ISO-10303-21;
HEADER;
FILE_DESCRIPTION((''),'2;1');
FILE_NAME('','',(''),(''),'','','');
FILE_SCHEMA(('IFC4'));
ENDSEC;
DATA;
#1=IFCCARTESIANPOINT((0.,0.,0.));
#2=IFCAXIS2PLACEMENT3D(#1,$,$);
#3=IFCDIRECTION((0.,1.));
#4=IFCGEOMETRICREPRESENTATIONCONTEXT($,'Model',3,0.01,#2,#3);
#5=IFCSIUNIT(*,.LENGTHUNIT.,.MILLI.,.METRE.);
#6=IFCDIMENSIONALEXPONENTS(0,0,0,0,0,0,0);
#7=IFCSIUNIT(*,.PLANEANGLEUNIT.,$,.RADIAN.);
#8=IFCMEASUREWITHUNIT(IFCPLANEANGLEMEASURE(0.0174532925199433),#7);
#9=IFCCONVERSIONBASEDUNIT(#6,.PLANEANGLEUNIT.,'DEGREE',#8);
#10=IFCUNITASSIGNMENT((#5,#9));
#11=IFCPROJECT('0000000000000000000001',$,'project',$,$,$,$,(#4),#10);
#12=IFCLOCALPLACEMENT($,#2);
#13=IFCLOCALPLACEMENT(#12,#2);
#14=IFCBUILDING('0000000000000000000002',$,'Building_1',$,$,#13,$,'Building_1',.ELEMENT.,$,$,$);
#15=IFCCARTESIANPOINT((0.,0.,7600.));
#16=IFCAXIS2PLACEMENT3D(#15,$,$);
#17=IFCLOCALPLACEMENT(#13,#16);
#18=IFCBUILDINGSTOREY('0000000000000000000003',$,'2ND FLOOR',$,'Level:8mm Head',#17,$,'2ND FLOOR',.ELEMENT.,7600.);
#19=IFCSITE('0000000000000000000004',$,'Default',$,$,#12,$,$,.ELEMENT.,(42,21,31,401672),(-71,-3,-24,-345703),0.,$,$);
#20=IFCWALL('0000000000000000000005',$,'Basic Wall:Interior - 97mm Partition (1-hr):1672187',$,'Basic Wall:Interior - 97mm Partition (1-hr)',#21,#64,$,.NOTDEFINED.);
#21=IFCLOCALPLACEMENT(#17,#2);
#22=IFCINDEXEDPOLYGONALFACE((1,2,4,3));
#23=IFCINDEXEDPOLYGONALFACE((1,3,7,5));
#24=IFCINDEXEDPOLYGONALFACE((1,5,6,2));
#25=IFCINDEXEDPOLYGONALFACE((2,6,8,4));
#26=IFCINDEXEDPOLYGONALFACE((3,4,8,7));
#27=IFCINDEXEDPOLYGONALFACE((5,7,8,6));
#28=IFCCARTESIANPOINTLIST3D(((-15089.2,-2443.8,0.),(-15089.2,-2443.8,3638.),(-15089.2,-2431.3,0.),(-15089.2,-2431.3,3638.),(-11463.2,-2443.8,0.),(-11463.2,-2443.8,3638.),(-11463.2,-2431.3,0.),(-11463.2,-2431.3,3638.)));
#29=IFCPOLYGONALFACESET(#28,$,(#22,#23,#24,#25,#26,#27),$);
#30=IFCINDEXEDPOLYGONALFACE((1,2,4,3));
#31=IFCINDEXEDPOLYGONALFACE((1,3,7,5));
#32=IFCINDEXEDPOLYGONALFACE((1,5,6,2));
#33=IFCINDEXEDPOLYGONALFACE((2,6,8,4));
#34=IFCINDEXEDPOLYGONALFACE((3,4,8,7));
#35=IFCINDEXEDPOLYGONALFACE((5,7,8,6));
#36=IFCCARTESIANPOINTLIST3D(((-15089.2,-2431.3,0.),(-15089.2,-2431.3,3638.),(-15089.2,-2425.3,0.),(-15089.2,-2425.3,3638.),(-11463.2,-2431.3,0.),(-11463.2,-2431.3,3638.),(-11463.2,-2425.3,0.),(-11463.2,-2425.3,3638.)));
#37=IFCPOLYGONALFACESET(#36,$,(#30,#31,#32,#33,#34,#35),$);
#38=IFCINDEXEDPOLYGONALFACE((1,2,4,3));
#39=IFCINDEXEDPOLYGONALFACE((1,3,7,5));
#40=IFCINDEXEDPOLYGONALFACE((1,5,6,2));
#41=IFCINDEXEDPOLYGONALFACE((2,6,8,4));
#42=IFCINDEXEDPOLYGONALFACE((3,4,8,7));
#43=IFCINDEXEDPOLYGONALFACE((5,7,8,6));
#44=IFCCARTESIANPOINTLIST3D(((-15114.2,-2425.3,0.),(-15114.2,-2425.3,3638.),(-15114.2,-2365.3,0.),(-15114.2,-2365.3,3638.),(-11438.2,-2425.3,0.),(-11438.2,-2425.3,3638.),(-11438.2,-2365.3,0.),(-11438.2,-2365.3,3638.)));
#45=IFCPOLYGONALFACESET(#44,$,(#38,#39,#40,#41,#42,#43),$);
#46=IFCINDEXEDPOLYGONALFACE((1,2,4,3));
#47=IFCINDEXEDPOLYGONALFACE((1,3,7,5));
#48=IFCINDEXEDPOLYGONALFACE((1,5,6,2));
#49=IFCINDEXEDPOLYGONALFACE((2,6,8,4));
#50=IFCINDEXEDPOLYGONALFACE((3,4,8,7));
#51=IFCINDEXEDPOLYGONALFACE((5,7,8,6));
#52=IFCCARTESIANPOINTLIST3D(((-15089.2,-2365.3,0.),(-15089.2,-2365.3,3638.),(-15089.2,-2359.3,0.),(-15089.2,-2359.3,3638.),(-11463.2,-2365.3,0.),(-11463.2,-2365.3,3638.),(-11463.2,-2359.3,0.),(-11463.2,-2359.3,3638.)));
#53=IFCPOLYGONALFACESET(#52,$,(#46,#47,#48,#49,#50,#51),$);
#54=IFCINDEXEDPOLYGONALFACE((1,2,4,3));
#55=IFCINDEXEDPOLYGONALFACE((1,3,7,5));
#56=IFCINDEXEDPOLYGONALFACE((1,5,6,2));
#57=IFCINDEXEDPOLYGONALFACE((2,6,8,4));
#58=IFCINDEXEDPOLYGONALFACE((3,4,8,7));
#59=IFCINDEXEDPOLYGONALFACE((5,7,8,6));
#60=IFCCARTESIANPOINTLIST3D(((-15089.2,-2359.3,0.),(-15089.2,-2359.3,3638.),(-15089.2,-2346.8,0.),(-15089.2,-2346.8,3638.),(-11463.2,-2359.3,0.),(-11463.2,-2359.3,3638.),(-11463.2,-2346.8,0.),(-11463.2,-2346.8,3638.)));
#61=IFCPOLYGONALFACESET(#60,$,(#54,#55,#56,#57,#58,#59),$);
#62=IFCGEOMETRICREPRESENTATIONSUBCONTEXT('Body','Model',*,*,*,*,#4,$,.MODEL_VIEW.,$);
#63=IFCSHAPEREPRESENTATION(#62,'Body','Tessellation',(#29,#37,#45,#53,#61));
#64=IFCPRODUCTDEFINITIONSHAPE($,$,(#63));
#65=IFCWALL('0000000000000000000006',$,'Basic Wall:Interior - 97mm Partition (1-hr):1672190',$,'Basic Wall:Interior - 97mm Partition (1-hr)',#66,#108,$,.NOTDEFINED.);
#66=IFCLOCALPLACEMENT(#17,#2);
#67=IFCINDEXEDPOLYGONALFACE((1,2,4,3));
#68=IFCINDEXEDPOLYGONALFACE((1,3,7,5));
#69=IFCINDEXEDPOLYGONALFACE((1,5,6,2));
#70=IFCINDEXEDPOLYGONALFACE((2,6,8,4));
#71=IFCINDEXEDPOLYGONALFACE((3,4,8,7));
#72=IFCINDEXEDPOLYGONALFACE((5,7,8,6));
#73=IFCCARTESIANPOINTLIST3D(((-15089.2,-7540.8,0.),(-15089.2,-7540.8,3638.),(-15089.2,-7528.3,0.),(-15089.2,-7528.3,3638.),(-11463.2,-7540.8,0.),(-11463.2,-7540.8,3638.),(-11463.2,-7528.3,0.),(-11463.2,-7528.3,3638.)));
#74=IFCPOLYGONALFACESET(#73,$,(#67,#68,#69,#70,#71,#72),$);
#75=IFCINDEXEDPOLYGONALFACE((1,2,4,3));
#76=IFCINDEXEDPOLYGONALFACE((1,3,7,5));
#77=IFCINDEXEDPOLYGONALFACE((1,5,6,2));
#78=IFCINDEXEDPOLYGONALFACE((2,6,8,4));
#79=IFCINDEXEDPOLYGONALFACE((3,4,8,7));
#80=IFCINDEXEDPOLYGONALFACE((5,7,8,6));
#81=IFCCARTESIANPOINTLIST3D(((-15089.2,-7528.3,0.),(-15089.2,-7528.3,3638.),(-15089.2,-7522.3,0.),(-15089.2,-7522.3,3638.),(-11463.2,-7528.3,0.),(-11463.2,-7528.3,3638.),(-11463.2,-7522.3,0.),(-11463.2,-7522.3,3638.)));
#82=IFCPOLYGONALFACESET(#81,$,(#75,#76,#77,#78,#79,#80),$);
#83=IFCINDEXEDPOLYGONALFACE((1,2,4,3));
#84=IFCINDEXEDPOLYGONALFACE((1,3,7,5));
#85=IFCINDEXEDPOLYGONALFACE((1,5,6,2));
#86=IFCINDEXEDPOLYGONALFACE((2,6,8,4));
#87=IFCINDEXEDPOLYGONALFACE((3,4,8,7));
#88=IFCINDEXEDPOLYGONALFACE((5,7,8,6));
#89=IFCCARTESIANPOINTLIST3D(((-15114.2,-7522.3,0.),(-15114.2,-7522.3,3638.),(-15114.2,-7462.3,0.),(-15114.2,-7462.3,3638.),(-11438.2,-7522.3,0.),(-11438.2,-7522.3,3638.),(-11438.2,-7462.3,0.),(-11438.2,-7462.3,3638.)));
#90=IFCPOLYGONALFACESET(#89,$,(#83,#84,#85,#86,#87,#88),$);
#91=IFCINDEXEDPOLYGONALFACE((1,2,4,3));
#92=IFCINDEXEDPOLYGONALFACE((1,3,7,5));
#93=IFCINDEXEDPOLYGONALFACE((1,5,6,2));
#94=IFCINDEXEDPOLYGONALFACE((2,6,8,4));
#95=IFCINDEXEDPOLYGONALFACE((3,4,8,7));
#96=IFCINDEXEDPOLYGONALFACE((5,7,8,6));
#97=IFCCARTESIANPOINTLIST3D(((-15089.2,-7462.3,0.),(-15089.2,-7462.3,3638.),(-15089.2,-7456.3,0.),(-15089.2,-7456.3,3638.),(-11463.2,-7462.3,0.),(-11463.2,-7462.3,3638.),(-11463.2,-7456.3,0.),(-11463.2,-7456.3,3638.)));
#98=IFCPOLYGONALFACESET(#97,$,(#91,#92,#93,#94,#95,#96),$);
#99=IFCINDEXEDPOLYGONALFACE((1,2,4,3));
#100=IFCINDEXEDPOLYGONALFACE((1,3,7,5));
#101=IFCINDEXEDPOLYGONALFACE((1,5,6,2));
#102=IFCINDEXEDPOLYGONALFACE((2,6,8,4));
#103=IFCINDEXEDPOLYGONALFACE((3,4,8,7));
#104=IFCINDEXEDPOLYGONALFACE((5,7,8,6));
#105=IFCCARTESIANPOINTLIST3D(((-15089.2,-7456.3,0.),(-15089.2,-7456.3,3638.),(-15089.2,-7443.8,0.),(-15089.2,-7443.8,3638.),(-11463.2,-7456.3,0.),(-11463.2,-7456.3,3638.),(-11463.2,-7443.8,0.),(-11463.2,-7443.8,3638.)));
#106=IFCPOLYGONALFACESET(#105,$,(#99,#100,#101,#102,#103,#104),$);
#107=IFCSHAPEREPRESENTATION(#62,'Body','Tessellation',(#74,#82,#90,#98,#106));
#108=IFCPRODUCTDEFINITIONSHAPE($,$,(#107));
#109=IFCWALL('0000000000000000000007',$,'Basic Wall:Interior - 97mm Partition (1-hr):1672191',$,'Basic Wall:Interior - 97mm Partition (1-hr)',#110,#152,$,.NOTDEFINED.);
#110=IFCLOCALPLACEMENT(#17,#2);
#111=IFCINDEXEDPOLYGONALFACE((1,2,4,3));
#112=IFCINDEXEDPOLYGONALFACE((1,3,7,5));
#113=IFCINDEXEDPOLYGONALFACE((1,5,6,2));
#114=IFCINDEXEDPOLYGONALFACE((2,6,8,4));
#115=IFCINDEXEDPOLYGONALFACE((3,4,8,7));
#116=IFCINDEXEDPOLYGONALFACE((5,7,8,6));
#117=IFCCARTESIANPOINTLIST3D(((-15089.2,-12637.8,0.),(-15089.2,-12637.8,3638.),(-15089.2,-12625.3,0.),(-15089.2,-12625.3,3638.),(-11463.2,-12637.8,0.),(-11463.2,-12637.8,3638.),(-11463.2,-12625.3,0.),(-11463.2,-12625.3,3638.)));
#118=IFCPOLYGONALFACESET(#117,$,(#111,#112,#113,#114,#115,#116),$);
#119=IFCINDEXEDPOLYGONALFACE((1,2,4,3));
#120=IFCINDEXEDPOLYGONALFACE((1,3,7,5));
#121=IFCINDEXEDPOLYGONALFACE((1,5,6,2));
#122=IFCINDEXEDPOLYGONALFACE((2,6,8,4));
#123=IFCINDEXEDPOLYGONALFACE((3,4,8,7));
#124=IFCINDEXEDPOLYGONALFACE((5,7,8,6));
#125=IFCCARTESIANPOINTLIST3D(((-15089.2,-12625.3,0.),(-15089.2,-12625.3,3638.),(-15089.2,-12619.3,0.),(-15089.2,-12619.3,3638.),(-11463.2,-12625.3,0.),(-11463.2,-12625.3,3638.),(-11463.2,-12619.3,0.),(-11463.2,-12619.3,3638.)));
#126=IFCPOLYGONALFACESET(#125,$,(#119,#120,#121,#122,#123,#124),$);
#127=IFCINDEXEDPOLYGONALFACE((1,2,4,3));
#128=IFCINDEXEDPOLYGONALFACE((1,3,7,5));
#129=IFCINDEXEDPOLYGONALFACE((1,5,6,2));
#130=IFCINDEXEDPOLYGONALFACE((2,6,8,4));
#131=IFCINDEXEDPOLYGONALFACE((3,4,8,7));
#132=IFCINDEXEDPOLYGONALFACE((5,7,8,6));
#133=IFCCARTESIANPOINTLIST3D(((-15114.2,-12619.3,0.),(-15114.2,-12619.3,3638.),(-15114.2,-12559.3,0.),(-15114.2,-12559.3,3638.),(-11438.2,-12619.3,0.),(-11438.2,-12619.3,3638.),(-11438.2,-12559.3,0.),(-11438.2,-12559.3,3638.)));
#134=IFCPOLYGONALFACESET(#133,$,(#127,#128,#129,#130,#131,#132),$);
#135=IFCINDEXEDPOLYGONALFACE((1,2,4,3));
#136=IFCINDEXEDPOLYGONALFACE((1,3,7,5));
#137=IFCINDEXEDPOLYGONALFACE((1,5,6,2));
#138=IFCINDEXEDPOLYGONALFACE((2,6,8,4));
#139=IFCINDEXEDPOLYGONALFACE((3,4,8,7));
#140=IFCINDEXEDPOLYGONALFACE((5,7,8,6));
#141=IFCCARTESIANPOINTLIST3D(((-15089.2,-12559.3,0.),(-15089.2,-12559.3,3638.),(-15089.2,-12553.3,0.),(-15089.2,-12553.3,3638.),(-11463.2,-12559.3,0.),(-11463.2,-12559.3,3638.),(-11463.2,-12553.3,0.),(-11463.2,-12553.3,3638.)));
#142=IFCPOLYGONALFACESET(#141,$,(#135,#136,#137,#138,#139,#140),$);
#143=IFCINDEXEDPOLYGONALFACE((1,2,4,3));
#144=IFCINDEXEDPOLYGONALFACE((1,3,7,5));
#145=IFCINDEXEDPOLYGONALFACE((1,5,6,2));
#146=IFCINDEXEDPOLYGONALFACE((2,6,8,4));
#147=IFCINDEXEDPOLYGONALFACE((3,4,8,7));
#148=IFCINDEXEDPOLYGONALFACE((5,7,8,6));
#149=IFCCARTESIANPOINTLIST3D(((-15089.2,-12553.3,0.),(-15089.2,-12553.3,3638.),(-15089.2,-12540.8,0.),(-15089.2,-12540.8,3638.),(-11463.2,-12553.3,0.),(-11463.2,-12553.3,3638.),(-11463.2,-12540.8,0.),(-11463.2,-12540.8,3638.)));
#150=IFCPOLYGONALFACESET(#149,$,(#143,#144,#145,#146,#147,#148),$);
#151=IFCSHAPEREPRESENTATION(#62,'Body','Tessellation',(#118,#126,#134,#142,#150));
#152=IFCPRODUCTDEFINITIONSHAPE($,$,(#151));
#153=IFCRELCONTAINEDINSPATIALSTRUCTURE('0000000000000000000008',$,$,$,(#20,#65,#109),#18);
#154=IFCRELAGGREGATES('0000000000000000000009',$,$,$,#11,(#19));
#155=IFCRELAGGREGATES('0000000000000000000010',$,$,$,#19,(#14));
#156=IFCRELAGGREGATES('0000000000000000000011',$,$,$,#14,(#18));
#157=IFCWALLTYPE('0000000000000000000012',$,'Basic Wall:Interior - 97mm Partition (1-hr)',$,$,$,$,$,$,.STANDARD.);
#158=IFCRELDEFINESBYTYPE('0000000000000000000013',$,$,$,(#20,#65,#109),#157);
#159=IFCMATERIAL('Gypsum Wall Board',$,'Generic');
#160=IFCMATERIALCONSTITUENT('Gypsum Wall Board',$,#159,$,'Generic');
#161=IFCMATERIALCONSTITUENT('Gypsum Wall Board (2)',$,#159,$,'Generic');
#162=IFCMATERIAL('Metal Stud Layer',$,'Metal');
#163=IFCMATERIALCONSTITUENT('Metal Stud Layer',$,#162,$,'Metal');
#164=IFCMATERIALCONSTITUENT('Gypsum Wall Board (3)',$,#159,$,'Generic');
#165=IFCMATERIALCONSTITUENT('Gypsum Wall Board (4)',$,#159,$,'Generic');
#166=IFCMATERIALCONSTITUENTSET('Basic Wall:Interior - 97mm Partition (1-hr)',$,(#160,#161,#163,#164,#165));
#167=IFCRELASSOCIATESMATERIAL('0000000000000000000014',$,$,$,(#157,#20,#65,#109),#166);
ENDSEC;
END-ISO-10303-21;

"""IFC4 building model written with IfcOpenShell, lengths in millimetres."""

from ifc_helpers import new_model, entity, si_unit, converted_unit, direction, frame, origin, place, context, subcontext, project, spatial, indexed_curve, outline, extrude, material, constituent, constituent_set, type_object, element, save


model = new_model("IFC4")

# Units and contexts
model_context = context("Model", 3, precision=0.01, world=origin(), true_north=direction((0.0, 1.0)))
body_context = subcontext(model_context, "Body", "Model", "MODEL_VIEW")
ifc_project = project(units=[si_unit("LENGTHUNIT", "METRE", prefix="MILLI"), converted_unit("PLANEANGLEUNIT", "DEGREE", entity("IfcPlaneAngleMeasure", 0.0174532925199433), si_unit("PLANEANGLEUNIT", "RADIAN"), dimensions=[0, 0, 0, 0, 0, 0, 0])], contexts=[model_context])

# Site, building, storey
site_placement = place(None, origin())
site = spatial("IfcSite", under=ifc_project, at=site_placement, Name="Default", CompositionType="ELEMENT", RefLatitude=(42, 21, 31, 401672), RefLongitude=(-71, -3, -24, -345703), RefElevation=0.0)
building_placement = place(site_placement, origin())
building = spatial("IfcBuilding", under=site, at=building_placement, Name="Building_1", LongName="Building_1", CompositionType="ELEMENT")
storey_placement = place(building_placement, frame((0.0, 0.0, 7600.0)))
storey = spatial("IfcBuildingStorey", under=building, at=storey_placement, Name="2ND FLOOR", ObjectType="Level:8mm Head", LongName="2ND FLOOR", CompositionType="ELEMENT", Elevation=7600.0)

# Walls
ifc_material_1 = material(Name="Gypsum Wall Board", Category="Generic")
ifc_constituent_1 = constituent(ifc_material_1, Name="Gypsum Wall Board", Category="Generic")
ifc_constituent_2 = constituent(ifc_material_1, Name="Gypsum Wall Board (2)", Category="Generic")
ifc_material_2 = material(Name="Metal Stud Layer", Category="Metal")
ifc_constituent_3 = constituent(ifc_material_2, Name="Metal Stud Layer", Category="Metal")
ifc_constituent_4 = constituent(ifc_material_1, Name="Gypsum Wall Board (3)", Category="Generic")
ifc_constituent_5 = constituent(ifc_material_1, Name="Gypsum Wall Board (4)", Category="Generic")
ifc_constituent_set_1 = constituent_set(constituents=[ifc_constituent_1, ifc_constituent_2, ifc_constituent_3, ifc_constituent_4, ifc_constituent_5], Name="Basic Wall:Interior - 97mm Partition (1-hr)")
wall_type_1 = type_object("IfcWallType", Name="Basic Wall:Interior - 97mm Partition (1-hr)", PredefinedType="STANDARD", material=ifc_constituent_set_1)
wall_1_placement = place(storey_placement, frame((-15089.2, -2395.3, 0.0)))
element("IfcWall", 1, at=wall_1_placement, inside=storey, type_object=wall_type_1, material=ifc_constituent_set_1, Name="Basic Wall:Interior - 97mm Partition (1-hr):1672187", ObjectType="Basic Wall:Interior - 97mm Partition (1-hr)", PredefinedType="NOTDEFINED", context=body_context, shape_type="SweptSolid", body=[
    extrude(outline(indexed_curve([(-6.3, -1813.0), (6.2, -1813.0), (6.3, 1813.0), (-6.2, 1813.0), (-6.3, -1813.0)], self_intersect=False)), frame((1813.0, -42.2, 0.0), z_axis=(0.0, 0.0, 1.0), x_axis=(0.0, 1.0, 0.0)), (0.0, 0.0, 1.0), 3638.0),
    extrude(outline(indexed_curve([(-1813.0, -3.0), (1813.0, -3.0), (1813.0, 3.0), (-1813.0, 3.0), (-1813.0, -3.0)], self_intersect=False)), frame((1813.0, -33.0, 0.0)), (0.0, 0.0, 1.0), 3638.0),
    extrude(outline(indexed_curve([(-1838.0, -30.0), (1838.0, -30.0), (1838.0, 30.0), (-1838.0, 30.0), (-1838.0, -30.0)], self_intersect=False)), frame((1813.0, 0.0, 0.0)), (0.0, 0.0, 1.0), 3638.0),
    extrude(outline(indexed_curve([(-1813.0, -3.0), (1813.0, -3.0), (1813.0, 3.0), (-1813.0, 3.0), (-1813.0, -3.0)], self_intersect=False)), frame((1813.0, 33.0, 0.0)), (0.0, 0.0, 1.0), 3638.0),
    extrude(outline(indexed_curve([(-6.3, -1813.0), (6.2, -1813.0), (6.3, 1813.0), (-6.2, 1813.0), (-6.3, -1813.0)], self_intersect=False)), frame((1813.0, 42.3, 0.0), z_axis=(0.0, 0.0, 1.0), x_axis=(0.0, -1.0, 0.0)), (0.0, 0.0, 1.0), 3638.0),
])
wall_2_placement = place(storey_placement, frame((-15089.2, -7492.3, 0.0)))
element("IfcWall", 2, at=wall_2_placement, inside=storey, type_object=wall_type_1, material=ifc_constituent_set_1, Name="Basic Wall:Interior - 97mm Partition (1-hr):1672190", ObjectType="Basic Wall:Interior - 97mm Partition (1-hr)", PredefinedType="NOTDEFINED", context=body_context, shape_type="SweptSolid", body=[
    extrude(outline(indexed_curve([(-6.3, -1813.0), (6.2, -1813.0), (6.3, 1813.0), (-6.2, 1813.0), (-6.3, -1813.0)], self_intersect=False)), frame((1813.0, -42.2, 0.0), z_axis=(0.0, 0.0, 1.0), x_axis=(0.0, 1.0, 0.0)), (0.0, 0.0, 1.0), 3638.0),
    extrude(outline(indexed_curve([(-1813.0, -3.0), (1813.0, -3.0), (1813.0, 3.0), (-1813.0, 3.0), (-1813.0, -3.0)], self_intersect=False)), frame((1813.0, -33.0, 0.0)), (0.0, 0.0, 1.0), 3638.0),
    extrude(outline(indexed_curve([(-1838.0, -30.0), (1838.0, -30.0), (1838.0, 30.0), (-1838.0, 30.0), (-1838.0, -30.0)], self_intersect=False)), frame((1813.0, 0.0, 0.0)), (0.0, 0.0, 1.0), 3638.0),
    extrude(outline(indexed_curve([(-1813.0, -3.0), (1813.0, -3.0), (1813.0, 3.0), (-1813.0, 3.0), (-1813.0, -3.0)], self_intersect=False)), frame((1813.0, 33.0, 0.0)), (0.0, 0.0, 1.0), 3638.0),
    extrude(outline(indexed_curve([(-6.3, -1813.0), (6.2, -1813.0), (6.3, 1813.0), (-6.2, 1813.0), (-6.3, -1813.0)], self_intersect=False)), frame((1813.0, 42.3, 0.0), z_axis=(0.0, 0.0, 1.0), x_axis=(0.0, -1.0, 0.0)), (0.0, 0.0, 1.0), 3638.0),
])
wall_3_placement = place(storey_placement, frame((-15089.2, -12589.3, 0.0)))
element("IfcWall", 3, at=wall_3_placement, inside=storey, type_object=wall_type_1, material=ifc_constituent_set_1, Name="Basic Wall:Interior - 97mm Partition (1-hr):1672191", ObjectType="Basic Wall:Interior - 97mm Partition (1-hr)", PredefinedType="NOTDEFINED", context=body_context, shape_type="SweptSolid", body=[
    extrude(outline(indexed_curve([(-6.3, -1813.0), (6.2, -1813.0), (6.3, 1813.0), (-6.2, 1813.0), (-6.3, -1813.0)], self_intersect=False)), frame((1813.0, -42.2, 0.0), z_axis=(0.0, 0.0, 1.0), x_axis=(0.0, 1.0, 0.0)), (0.0, 0.0, 1.0), 3638.0),
    extrude(outline(indexed_curve([(-1813.0, -3.0), (1813.0, -3.0), (1813.0, 3.0), (-1813.0, 3.0), (-1813.0, -3.0)], self_intersect=False)), frame((1813.0, -33.0, 0.0)), (0.0, 0.0, 1.0), 3638.0),
    extrude(outline(indexed_curve([(-1838.0, -30.0), (1838.0, -30.0), (1838.0, 30.0), (-1838.0, 30.0), (-1838.0, -30.0)], self_intersect=False)), frame((1813.0, 0.0, 0.0)), (0.0, 0.0, 1.0), 3638.0),
    extrude(outline(indexed_curve([(-1813.0, -3.0), (1813.0, -3.0), (1813.0, 3.0), (-1813.0, 3.0), (-1813.0, -3.0)], self_intersect=False)), frame((1813.0, 33.0, 0.0)), (0.0, 0.0, 1.0), 3638.0),
    extrude(outline(indexed_curve([(-6.3, -1813.0), (6.2, -1813.0), (6.3, 1813.0), (-6.2, 1813.0), (-6.3, -1813.0)], self_intersect=False)), frame((1813.0, 42.2, 0.0), z_axis=(0.0, 0.0, 1.0), x_axis=(0.0, -1.0, 0.0)), (0.0, 0.0, 1.0), 3638.0),
])

save(model, "model.ifc")
